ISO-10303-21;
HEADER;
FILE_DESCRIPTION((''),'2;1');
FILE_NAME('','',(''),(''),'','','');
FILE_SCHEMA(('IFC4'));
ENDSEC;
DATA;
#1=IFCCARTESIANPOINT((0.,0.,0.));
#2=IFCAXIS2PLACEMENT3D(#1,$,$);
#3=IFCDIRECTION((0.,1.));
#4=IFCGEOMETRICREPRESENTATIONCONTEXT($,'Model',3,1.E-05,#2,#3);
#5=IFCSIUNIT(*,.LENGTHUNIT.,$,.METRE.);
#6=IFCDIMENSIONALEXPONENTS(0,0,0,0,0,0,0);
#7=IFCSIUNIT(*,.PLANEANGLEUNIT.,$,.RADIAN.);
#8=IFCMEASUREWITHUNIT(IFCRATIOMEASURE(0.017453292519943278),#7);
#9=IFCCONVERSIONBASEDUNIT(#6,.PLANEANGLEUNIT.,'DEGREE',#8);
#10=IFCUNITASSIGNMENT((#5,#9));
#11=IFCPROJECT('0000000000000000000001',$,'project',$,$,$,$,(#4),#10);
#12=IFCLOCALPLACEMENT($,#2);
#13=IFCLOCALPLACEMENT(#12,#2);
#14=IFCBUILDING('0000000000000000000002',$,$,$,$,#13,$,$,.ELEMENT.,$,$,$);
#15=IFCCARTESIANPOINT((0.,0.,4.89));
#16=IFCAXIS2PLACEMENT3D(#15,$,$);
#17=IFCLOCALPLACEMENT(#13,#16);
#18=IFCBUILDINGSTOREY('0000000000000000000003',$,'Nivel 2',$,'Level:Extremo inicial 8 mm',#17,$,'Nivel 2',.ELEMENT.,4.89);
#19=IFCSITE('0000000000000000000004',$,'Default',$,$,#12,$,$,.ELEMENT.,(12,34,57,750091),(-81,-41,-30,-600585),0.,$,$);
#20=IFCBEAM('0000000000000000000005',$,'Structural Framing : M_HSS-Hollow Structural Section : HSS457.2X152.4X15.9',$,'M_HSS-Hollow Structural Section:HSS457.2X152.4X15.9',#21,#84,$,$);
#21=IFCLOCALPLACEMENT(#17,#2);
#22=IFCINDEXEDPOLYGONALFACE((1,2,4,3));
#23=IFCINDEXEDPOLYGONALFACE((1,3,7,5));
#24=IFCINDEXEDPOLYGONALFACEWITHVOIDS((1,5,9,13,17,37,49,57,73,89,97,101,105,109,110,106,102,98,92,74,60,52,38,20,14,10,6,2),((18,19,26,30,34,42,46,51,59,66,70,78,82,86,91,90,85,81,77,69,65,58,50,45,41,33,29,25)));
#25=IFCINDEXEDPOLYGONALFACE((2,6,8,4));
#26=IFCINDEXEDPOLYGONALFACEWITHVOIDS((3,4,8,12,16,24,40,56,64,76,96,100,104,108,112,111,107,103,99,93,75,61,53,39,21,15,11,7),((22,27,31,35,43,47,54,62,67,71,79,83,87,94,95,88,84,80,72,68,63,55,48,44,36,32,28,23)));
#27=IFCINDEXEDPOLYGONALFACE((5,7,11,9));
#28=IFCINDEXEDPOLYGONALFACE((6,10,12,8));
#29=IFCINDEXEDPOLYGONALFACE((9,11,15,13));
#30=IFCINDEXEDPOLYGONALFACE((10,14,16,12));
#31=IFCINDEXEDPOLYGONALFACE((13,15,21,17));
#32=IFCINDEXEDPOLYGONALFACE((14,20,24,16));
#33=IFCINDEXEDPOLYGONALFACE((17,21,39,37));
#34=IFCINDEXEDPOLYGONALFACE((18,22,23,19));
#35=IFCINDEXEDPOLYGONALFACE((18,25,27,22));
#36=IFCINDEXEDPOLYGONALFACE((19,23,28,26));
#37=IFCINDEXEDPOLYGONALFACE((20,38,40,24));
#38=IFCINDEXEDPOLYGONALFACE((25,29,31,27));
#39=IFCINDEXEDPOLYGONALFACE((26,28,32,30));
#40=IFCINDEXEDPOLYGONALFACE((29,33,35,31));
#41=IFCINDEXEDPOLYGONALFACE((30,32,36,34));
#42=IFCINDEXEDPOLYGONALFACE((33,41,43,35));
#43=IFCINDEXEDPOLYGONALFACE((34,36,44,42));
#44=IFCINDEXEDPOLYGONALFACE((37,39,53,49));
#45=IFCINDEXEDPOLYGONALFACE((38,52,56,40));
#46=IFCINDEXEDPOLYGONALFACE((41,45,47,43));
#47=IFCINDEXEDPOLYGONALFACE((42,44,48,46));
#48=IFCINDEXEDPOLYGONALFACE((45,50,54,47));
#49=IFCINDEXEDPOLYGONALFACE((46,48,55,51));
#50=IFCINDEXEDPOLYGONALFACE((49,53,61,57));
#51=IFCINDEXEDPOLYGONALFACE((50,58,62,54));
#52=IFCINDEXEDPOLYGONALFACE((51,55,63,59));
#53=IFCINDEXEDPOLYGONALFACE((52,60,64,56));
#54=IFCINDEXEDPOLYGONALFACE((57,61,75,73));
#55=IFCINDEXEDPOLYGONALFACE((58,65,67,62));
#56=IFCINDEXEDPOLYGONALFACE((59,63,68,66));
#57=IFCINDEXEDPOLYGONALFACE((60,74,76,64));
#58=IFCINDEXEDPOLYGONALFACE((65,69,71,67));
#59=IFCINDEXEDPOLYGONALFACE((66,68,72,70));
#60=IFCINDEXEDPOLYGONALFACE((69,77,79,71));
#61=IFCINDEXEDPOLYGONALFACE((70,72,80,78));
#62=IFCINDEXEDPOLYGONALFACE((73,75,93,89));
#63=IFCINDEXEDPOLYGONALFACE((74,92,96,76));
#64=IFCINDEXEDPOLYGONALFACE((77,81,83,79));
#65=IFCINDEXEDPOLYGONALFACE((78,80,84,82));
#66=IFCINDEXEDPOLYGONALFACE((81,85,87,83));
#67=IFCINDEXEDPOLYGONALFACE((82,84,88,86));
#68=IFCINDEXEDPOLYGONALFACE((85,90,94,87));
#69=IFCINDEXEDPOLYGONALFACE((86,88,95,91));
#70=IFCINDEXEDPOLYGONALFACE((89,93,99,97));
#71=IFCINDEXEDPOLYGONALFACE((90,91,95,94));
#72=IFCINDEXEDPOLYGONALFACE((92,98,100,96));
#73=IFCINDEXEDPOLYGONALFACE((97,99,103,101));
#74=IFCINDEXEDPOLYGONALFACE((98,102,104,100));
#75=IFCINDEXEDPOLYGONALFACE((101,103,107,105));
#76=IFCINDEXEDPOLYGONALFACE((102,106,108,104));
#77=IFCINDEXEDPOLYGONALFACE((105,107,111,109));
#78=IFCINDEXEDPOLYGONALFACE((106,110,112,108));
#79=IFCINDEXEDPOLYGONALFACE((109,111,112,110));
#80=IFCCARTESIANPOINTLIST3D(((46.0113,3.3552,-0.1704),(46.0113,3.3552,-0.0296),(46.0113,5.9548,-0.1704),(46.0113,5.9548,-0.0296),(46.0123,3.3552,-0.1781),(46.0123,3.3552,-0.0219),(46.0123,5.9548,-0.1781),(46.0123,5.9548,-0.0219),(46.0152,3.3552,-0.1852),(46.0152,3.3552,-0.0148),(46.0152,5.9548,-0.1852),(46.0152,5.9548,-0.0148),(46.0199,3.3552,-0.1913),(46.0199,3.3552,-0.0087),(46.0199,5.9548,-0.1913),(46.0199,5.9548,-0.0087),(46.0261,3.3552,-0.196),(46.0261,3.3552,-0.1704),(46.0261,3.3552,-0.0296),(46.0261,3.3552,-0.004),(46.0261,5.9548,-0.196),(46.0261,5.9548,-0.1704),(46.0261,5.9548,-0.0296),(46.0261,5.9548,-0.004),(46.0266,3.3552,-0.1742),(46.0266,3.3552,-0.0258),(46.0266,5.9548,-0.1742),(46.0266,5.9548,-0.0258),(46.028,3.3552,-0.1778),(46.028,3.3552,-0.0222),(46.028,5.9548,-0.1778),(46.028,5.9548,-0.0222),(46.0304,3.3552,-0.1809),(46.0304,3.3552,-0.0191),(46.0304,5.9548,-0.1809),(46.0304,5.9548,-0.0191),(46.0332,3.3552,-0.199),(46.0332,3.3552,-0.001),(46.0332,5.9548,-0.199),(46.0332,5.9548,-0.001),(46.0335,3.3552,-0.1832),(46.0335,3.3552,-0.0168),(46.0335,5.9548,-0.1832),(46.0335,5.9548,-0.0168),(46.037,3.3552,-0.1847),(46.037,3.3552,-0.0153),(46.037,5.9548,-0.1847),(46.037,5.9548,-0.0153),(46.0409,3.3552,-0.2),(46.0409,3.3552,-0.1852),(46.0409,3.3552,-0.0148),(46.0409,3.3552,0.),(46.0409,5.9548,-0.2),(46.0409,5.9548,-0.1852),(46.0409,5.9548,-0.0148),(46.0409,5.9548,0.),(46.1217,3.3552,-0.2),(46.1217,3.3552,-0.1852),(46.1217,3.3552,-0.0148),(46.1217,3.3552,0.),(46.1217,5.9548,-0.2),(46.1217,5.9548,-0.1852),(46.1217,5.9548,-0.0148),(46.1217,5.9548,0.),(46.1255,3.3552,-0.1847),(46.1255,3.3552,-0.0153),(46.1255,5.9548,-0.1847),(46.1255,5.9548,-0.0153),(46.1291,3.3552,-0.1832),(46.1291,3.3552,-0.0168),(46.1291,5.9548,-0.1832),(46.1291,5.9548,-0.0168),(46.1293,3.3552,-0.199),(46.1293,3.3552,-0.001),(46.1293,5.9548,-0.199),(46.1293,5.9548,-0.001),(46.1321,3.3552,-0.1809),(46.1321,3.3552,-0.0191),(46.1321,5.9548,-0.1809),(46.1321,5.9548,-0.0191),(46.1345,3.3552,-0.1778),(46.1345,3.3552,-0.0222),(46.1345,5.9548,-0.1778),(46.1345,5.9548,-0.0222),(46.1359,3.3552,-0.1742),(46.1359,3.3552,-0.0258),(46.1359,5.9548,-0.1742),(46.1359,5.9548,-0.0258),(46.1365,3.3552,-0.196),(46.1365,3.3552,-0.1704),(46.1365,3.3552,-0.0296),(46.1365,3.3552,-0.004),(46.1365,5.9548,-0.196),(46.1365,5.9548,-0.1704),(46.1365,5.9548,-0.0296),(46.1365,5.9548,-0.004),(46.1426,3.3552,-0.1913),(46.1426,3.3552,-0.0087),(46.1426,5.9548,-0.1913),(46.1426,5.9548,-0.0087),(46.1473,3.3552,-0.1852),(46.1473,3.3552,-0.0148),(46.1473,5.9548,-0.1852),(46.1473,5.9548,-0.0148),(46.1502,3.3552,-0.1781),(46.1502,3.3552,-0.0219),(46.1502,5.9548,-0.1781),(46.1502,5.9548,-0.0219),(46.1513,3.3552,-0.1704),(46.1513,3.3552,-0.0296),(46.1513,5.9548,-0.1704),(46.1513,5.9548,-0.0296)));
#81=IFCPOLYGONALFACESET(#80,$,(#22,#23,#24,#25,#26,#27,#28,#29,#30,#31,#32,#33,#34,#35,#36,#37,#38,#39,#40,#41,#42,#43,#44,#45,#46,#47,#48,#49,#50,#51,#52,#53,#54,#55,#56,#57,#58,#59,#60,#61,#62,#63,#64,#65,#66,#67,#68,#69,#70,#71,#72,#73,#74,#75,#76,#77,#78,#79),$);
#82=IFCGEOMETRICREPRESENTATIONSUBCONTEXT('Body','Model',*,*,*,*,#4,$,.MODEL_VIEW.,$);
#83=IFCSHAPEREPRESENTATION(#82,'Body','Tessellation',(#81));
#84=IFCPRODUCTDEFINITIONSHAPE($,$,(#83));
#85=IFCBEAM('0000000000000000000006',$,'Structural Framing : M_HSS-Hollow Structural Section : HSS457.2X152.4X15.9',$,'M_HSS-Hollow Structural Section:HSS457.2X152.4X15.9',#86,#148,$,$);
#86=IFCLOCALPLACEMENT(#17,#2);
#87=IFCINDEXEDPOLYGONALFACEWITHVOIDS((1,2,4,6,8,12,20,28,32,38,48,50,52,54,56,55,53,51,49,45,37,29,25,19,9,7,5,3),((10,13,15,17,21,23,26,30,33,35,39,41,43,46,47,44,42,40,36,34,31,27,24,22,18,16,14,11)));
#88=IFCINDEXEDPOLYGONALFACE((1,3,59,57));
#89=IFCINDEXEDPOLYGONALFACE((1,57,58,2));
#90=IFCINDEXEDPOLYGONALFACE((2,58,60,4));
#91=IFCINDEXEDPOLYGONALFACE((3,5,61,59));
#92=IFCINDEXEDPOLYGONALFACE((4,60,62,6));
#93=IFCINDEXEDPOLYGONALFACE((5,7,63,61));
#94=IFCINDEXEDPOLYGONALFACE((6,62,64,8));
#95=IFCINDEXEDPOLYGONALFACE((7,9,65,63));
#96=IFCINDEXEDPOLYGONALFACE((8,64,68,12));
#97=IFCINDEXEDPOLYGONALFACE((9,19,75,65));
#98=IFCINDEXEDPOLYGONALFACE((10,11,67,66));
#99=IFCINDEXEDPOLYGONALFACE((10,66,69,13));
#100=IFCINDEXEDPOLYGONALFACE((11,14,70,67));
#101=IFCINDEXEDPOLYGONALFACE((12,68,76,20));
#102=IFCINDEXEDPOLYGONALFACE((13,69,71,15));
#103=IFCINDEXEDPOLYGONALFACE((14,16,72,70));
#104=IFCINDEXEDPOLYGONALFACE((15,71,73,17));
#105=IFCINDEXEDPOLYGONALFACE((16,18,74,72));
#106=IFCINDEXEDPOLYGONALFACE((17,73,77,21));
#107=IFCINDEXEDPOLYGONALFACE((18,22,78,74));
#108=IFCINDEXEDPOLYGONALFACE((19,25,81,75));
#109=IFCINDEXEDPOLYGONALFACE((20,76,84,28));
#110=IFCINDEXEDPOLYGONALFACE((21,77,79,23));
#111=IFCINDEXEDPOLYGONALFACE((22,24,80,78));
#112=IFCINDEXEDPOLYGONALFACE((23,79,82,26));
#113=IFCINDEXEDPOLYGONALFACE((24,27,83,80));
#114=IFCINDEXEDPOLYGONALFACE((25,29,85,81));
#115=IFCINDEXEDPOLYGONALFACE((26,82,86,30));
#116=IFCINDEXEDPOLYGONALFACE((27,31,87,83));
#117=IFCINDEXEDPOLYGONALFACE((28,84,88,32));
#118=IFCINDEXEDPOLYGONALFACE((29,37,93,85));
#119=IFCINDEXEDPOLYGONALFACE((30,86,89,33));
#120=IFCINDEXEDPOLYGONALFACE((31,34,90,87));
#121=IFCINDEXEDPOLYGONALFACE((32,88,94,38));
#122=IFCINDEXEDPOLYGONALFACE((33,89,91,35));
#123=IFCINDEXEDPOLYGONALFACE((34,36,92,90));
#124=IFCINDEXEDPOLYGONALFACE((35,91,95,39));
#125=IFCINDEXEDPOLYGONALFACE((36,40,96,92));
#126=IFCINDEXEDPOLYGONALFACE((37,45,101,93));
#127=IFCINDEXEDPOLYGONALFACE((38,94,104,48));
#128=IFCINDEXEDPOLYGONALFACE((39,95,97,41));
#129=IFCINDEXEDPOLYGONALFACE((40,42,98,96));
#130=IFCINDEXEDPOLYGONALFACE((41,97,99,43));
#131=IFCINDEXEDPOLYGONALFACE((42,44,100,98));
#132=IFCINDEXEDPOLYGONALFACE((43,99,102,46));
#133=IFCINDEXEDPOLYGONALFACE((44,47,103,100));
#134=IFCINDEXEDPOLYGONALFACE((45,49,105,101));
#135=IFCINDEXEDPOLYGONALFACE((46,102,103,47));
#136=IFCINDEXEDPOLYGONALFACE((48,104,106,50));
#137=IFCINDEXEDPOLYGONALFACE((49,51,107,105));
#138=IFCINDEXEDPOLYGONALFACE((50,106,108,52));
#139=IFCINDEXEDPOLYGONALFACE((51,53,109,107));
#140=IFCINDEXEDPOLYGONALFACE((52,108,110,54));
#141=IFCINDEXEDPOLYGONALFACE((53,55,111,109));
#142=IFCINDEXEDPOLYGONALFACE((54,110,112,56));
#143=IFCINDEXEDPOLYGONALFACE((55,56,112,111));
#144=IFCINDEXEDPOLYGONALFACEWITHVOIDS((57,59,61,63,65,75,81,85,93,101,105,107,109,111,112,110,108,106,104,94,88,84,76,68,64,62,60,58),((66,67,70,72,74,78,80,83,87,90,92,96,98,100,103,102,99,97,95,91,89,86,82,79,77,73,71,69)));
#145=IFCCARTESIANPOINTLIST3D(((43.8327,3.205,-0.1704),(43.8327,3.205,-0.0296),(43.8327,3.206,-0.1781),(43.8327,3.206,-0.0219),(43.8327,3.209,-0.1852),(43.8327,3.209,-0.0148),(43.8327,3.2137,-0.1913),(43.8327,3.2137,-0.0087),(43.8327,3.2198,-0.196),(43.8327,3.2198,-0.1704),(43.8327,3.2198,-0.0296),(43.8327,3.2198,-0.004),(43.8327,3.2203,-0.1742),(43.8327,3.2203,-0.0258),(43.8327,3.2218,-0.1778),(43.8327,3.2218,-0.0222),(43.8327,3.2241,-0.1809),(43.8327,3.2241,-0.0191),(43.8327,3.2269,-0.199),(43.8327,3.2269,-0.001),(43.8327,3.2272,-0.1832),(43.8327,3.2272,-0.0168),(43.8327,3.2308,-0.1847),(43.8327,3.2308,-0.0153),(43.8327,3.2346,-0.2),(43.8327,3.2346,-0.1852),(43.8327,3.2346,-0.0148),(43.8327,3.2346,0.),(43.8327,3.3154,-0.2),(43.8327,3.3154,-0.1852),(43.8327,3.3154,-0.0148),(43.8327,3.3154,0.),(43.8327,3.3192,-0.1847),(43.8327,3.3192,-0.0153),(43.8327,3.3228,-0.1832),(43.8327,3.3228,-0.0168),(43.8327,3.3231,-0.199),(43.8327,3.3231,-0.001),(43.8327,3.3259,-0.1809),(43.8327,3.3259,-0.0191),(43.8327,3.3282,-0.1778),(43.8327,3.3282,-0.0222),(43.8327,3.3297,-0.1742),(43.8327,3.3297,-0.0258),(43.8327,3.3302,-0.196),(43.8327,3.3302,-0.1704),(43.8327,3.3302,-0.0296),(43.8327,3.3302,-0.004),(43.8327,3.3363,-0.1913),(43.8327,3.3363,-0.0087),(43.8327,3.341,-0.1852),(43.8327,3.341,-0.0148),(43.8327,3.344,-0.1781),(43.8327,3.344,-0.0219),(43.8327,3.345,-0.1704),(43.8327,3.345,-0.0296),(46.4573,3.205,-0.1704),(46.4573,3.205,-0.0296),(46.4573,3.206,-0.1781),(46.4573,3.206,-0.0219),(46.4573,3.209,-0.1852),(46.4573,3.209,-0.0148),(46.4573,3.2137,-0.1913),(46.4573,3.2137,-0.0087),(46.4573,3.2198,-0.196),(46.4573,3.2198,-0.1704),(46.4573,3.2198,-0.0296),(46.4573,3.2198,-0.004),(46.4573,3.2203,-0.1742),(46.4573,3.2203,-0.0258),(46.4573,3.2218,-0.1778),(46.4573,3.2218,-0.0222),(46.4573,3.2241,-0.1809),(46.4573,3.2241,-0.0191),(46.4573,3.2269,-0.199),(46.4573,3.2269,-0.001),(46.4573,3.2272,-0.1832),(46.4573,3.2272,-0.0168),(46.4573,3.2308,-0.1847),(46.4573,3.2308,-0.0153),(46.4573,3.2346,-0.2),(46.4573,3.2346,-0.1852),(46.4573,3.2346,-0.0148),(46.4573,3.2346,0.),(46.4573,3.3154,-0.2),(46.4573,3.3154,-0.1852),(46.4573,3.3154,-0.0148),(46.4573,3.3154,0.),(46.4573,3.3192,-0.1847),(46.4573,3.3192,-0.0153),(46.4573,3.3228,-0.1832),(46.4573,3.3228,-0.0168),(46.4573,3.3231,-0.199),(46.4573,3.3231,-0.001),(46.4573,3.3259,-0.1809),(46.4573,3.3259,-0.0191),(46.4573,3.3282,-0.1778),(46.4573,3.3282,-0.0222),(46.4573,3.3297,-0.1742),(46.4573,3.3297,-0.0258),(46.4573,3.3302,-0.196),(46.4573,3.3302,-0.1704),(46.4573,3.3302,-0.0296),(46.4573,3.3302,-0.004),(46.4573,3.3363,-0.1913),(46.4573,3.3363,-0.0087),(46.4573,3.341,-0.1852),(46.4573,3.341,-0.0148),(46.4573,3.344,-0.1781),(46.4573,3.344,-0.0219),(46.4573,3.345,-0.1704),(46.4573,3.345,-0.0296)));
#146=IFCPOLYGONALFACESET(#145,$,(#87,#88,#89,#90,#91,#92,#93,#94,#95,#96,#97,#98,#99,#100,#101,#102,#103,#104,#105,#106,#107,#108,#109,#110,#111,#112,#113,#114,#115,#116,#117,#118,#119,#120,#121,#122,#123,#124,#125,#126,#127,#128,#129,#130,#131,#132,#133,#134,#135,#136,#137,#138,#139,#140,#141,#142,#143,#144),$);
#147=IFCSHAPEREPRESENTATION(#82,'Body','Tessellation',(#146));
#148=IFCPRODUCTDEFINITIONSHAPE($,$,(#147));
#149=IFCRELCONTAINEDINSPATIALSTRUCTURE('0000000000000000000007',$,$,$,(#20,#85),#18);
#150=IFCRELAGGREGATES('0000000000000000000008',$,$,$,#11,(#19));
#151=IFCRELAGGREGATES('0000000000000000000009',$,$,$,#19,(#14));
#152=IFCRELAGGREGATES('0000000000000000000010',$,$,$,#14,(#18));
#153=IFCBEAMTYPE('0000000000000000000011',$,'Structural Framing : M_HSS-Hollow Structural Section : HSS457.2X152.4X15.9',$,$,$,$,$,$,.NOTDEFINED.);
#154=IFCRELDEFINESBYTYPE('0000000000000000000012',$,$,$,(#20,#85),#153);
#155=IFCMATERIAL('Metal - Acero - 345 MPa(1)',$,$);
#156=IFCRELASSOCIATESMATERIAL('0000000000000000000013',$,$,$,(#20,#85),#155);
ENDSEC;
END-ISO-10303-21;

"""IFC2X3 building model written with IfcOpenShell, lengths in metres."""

from ifc_helpers import new_model, entity, si_unit, converted_unit, direction, frame, frame_2d, origin, place, context, subcontext, project, spatial, polyline, circle_curve, parameter, trimmed, segment, composite_curve, outline, extrude, material, type_object, element, save


model = new_model("IFC2X3")

# Units and contexts
model_context = context("Model", 3, precision=1e-05, world=origin(), true_north=direction((0.0, 1.0)))
body_context = subcontext(model_context, "Body", "Model", "MODEL_VIEW")
ifc_project = project(units=[si_unit("LENGTHUNIT", "METRE"), converted_unit("PLANEANGLEUNIT", "DEGREE", entity("IfcRatioMeasure", 0.017453292519943278), si_unit("PLANEANGLEUNIT", "RADIAN"), dimensions=[0, 0, 0, 0, 0, 0, 0])], contexts=[model_context])

# Site, building, storey
site_placement = place(None, origin())
site = spatial("IfcSite", under=ifc_project, at=site_placement, Name="Default", CompositionType="ELEMENT", RefLatitude=(12, 34, 57, 750091), RefLongitude=(-81, -41, -30, -600585), RefElevation=0.0)
building_placement = place(site_placement, origin())
building = spatial("IfcBuilding", under=site, at=building_placement, CompositionType="ELEMENT")
storey_placement = place(building_placement, frame((0.0, 0.0, 4.89)))
storey = spatial("IfcBuildingStorey", under=building, at=storey_placement, Name="Nivel 2", ObjectType="Level:Extremo inicial 8 mm", LongName="Nivel 2", CompositionType="ELEMENT", Elevation=4.89)

# Shared definitions
ifc_material_1 = material(Name="Metal - Acero - 345 MPa(1)")

# Beams
beam_type_1 = type_object("IfcBeamType", Name="Structural Framing : M_HSS-Hollow Structural Section : HSS457.2X152.4X15.9", PredefinedType="NOTDEFINED")
beam_1_placement = place(storey_placement, frame((46.0813, 3.275, 0.0), z_axis=(0.0, 0.0, 1.0), x_axis=(0.0, 1.0, 0.0)))
element("IfcBeam", 1, at=beam_1_placement, inside=storey, type_object=beam_type_1, material=ifc_material_1, Name="Structural Framing : M_HSS-Hollow Structural Section : HSS457.2X152.4X15.9", ObjectType="M_HSS-Hollow Structural Section:HSS457.2X152.4X15.9", context=body_context, shape_type="SweptSolid", body=[
    extrude(outline(composite_curve([segment(trimmed(circle_curve(frame_2d((-0.0404, -0.0704), x_axis=(1.0, 0.0)), 0.0296), [parameter(180.0)], [parameter(270.0)], True, "PARAMETER"), True, "CONTINUOUS"), segment(polyline([(-0.0404, -0.1), (0.0404, -0.1)]), True, "CONTINUOUS"), segment(trimmed(circle_curve(frame_2d((0.0404, -0.0704), x_axis=(1.0, 0.0)), 0.0296), [parameter(270.0)], [parameter(0.0)], True, "PARAMETER"), True, "CONTINUOUS"), segment(polyline([(0.07, -0.0704), (0.07, 0.0704)]), True, "CONTINUOUS"), segment(trimmed(circle_curve(frame_2d((0.0404, 0.0704), x_axis=(1.0, 0.0)), 0.0296), [parameter(360.0)], [parameter(90.0)], True, "PARAMETER"), True, "CONTINUOUS"), segment(polyline([(0.0404, 0.1), (-0.0404, 0.1)]), True, "CONTINUOUS"), segment(trimmed(circle_curve(frame_2d((-0.0404, 0.0704), x_axis=(1.0, 0.0)), 0.0296), [parameter(90.0)], [parameter(180.0)], True, "PARAMETER"), True, "CONTINUOUS"), segment(polyline([(-0.07, 0.0704), (-0.07, -0.0704)]), True, "CONTINUOUS")], self_intersect=False), holes=[composite_curve([segment(polyline([(0.0404, -0.0852), (-0.0404, -0.0852)]), True, "CONTINUOUS"), segment(trimmed(circle_curve(frame_2d((-0.0404, -0.0704), x_axis=(1.0, 0.0)), 0.0148), [parameter(180.0)], [parameter(270.0)], True, "PARAMETER"), False, "CONTINUOUS"), segment(polyline([(-0.0552, -0.0704), (-0.0552, 0.0704)]), True, "CONTINUOUS"), segment(trimmed(circle_curve(frame_2d((-0.0404, 0.0704), x_axis=(1.0, 0.0)), 0.0148), [parameter(90.0)], [parameter(180.0)], True, "PARAMETER"), False, "CONTINUOUS"), segment(polyline([(-0.0404, 0.0852), (0.0404, 0.0852)]), True, "CONTINUOUS"), segment(trimmed(circle_curve(frame_2d((0.0404, 0.0704), x_axis=(1.0, 0.0)), 0.0148), [parameter(0.0)], [parameter(90.0)], True, "PARAMETER"), False, "CONTINUOUS"), segment(polyline([(0.0552, 0.0704), (0.0552, -0.0704)]), True, "CONTINUOUS"), segment(trimmed(circle_curve(frame_2d((0.0404, -0.0704), x_axis=(1.0, 0.0)), 0.0148), [parameter(270.0)], [parameter(0.0)], True, "PARAMETER"), False, "CONTINUOUS")], self_intersect=False)]), frame((0.0802, 0.0, -0.1), z_axis=(1.0, 0.0, 0.0), x_axis=(0.0, -1.0, 0.0)), (0.0, 0.0, 1.0), 2.5996),
])
beam_2_placement = place(storey_placement, frame((43.74, 3.275, 0.0)))
element("IfcBeam", 2, at=beam_2_placement, inside=storey, type_object=beam_type_1, material=ifc_material_1, Name="Structural Framing : M_HSS-Hollow Structural Section : HSS457.2X152.4X15.9", ObjectType="M_HSS-Hollow Structural Section:HSS457.2X152.4X15.9", context=body_context, shape_type="SweptSolid", body=[
    extrude(outline(composite_curve([segment(trimmed(circle_curve(frame_2d((-0.0404, -0.0704), x_axis=(1.0, 0.0)), 0.0296), [parameter(180.0)], [parameter(270.0)], True, "PARAMETER"), True, "CONTINUOUS"), segment(polyline([(-0.0404, -0.1), (0.0404, -0.1)]), True, "CONTINUOUS"), segment(trimmed(circle_curve(frame_2d((0.0404, -0.0704), x_axis=(1.0, 0.0)), 0.0296), [parameter(270.0)], [parameter(0.0)], True, "PARAMETER"), True, "CONTINUOUS"), segment(polyline([(0.07, -0.0704), (0.07, 0.0704)]), True, "CONTINUOUS"), segment(trimmed(circle_curve(frame_2d((0.0404, 0.0704), x_axis=(1.0, 0.0)), 0.0296), [parameter(360.0)], [parameter(90.0)], True, "PARAMETER"), True, "CONTINUOUS"), segment(polyline([(0.0404, 0.1), (-0.0404, 0.1)]), True, "CONTINUOUS"), segment(trimmed(circle_curve(frame_2d((-0.0404, 0.0704), x_axis=(1.0, 0.0)), 0.0296), [parameter(90.0)], [parameter(180.0)], True, "PARAMETER"), True, "CONTINUOUS"), segment(polyline([(-0.07, 0.0704), (-0.07, -0.0704)]), True, "CONTINUOUS")], self_intersect=False), holes=[composite_curve([segment(polyline([(0.0404, -0.0852), (-0.0404, -0.0852)]), True, "CONTINUOUS"), segment(trimmed(circle_curve(frame_2d((-0.0404, -0.0704), x_axis=(1.0, 0.0)), 0.0148), [parameter(180.0)], [parameter(270.0)], True, "PARAMETER"), False, "CONTINUOUS"), segment(polyline([(-0.0552, -0.0704), (-0.0552, 0.0704)]), True, "CONTINUOUS"), segment(trimmed(circle_curve(frame_2d((-0.0404, 0.0704), x_axis=(1.0, 0.0)), 0.0148), [parameter(90.0)], [parameter(180.0)], True, "PARAMETER"), False, "CONTINUOUS"), segment(polyline([(-0.0404, 0.0852), (0.0404, 0.0852)]), True, "CONTINUOUS"), segment(trimmed(circle_curve(frame_2d((0.0404, 0.0704), x_axis=(1.0, 0.0)), 0.0148), [parameter(0.0)], [parameter(90.0)], True, "PARAMETER"), False, "CONTINUOUS"), segment(polyline([(0.0552, 0.0704), (0.0552, -0.0704)]), True, "CONTINUOUS"), segment(trimmed(circle_curve(frame_2d((0.0404, -0.0704), x_axis=(1.0, 0.0)), 0.0148), [parameter(270.0)], [parameter(0.0)], True, "PARAMETER"), False, "CONTINUOUS")], self_intersect=False)]), frame((0.0927, 0.0, -0.1), z_axis=(1.0, 0.0, 0.0), x_axis=(0.0, -1.0, 0.0)), (0.0, 0.0, 1.0), 2.6246),
])

save(model, "model.ifc")
